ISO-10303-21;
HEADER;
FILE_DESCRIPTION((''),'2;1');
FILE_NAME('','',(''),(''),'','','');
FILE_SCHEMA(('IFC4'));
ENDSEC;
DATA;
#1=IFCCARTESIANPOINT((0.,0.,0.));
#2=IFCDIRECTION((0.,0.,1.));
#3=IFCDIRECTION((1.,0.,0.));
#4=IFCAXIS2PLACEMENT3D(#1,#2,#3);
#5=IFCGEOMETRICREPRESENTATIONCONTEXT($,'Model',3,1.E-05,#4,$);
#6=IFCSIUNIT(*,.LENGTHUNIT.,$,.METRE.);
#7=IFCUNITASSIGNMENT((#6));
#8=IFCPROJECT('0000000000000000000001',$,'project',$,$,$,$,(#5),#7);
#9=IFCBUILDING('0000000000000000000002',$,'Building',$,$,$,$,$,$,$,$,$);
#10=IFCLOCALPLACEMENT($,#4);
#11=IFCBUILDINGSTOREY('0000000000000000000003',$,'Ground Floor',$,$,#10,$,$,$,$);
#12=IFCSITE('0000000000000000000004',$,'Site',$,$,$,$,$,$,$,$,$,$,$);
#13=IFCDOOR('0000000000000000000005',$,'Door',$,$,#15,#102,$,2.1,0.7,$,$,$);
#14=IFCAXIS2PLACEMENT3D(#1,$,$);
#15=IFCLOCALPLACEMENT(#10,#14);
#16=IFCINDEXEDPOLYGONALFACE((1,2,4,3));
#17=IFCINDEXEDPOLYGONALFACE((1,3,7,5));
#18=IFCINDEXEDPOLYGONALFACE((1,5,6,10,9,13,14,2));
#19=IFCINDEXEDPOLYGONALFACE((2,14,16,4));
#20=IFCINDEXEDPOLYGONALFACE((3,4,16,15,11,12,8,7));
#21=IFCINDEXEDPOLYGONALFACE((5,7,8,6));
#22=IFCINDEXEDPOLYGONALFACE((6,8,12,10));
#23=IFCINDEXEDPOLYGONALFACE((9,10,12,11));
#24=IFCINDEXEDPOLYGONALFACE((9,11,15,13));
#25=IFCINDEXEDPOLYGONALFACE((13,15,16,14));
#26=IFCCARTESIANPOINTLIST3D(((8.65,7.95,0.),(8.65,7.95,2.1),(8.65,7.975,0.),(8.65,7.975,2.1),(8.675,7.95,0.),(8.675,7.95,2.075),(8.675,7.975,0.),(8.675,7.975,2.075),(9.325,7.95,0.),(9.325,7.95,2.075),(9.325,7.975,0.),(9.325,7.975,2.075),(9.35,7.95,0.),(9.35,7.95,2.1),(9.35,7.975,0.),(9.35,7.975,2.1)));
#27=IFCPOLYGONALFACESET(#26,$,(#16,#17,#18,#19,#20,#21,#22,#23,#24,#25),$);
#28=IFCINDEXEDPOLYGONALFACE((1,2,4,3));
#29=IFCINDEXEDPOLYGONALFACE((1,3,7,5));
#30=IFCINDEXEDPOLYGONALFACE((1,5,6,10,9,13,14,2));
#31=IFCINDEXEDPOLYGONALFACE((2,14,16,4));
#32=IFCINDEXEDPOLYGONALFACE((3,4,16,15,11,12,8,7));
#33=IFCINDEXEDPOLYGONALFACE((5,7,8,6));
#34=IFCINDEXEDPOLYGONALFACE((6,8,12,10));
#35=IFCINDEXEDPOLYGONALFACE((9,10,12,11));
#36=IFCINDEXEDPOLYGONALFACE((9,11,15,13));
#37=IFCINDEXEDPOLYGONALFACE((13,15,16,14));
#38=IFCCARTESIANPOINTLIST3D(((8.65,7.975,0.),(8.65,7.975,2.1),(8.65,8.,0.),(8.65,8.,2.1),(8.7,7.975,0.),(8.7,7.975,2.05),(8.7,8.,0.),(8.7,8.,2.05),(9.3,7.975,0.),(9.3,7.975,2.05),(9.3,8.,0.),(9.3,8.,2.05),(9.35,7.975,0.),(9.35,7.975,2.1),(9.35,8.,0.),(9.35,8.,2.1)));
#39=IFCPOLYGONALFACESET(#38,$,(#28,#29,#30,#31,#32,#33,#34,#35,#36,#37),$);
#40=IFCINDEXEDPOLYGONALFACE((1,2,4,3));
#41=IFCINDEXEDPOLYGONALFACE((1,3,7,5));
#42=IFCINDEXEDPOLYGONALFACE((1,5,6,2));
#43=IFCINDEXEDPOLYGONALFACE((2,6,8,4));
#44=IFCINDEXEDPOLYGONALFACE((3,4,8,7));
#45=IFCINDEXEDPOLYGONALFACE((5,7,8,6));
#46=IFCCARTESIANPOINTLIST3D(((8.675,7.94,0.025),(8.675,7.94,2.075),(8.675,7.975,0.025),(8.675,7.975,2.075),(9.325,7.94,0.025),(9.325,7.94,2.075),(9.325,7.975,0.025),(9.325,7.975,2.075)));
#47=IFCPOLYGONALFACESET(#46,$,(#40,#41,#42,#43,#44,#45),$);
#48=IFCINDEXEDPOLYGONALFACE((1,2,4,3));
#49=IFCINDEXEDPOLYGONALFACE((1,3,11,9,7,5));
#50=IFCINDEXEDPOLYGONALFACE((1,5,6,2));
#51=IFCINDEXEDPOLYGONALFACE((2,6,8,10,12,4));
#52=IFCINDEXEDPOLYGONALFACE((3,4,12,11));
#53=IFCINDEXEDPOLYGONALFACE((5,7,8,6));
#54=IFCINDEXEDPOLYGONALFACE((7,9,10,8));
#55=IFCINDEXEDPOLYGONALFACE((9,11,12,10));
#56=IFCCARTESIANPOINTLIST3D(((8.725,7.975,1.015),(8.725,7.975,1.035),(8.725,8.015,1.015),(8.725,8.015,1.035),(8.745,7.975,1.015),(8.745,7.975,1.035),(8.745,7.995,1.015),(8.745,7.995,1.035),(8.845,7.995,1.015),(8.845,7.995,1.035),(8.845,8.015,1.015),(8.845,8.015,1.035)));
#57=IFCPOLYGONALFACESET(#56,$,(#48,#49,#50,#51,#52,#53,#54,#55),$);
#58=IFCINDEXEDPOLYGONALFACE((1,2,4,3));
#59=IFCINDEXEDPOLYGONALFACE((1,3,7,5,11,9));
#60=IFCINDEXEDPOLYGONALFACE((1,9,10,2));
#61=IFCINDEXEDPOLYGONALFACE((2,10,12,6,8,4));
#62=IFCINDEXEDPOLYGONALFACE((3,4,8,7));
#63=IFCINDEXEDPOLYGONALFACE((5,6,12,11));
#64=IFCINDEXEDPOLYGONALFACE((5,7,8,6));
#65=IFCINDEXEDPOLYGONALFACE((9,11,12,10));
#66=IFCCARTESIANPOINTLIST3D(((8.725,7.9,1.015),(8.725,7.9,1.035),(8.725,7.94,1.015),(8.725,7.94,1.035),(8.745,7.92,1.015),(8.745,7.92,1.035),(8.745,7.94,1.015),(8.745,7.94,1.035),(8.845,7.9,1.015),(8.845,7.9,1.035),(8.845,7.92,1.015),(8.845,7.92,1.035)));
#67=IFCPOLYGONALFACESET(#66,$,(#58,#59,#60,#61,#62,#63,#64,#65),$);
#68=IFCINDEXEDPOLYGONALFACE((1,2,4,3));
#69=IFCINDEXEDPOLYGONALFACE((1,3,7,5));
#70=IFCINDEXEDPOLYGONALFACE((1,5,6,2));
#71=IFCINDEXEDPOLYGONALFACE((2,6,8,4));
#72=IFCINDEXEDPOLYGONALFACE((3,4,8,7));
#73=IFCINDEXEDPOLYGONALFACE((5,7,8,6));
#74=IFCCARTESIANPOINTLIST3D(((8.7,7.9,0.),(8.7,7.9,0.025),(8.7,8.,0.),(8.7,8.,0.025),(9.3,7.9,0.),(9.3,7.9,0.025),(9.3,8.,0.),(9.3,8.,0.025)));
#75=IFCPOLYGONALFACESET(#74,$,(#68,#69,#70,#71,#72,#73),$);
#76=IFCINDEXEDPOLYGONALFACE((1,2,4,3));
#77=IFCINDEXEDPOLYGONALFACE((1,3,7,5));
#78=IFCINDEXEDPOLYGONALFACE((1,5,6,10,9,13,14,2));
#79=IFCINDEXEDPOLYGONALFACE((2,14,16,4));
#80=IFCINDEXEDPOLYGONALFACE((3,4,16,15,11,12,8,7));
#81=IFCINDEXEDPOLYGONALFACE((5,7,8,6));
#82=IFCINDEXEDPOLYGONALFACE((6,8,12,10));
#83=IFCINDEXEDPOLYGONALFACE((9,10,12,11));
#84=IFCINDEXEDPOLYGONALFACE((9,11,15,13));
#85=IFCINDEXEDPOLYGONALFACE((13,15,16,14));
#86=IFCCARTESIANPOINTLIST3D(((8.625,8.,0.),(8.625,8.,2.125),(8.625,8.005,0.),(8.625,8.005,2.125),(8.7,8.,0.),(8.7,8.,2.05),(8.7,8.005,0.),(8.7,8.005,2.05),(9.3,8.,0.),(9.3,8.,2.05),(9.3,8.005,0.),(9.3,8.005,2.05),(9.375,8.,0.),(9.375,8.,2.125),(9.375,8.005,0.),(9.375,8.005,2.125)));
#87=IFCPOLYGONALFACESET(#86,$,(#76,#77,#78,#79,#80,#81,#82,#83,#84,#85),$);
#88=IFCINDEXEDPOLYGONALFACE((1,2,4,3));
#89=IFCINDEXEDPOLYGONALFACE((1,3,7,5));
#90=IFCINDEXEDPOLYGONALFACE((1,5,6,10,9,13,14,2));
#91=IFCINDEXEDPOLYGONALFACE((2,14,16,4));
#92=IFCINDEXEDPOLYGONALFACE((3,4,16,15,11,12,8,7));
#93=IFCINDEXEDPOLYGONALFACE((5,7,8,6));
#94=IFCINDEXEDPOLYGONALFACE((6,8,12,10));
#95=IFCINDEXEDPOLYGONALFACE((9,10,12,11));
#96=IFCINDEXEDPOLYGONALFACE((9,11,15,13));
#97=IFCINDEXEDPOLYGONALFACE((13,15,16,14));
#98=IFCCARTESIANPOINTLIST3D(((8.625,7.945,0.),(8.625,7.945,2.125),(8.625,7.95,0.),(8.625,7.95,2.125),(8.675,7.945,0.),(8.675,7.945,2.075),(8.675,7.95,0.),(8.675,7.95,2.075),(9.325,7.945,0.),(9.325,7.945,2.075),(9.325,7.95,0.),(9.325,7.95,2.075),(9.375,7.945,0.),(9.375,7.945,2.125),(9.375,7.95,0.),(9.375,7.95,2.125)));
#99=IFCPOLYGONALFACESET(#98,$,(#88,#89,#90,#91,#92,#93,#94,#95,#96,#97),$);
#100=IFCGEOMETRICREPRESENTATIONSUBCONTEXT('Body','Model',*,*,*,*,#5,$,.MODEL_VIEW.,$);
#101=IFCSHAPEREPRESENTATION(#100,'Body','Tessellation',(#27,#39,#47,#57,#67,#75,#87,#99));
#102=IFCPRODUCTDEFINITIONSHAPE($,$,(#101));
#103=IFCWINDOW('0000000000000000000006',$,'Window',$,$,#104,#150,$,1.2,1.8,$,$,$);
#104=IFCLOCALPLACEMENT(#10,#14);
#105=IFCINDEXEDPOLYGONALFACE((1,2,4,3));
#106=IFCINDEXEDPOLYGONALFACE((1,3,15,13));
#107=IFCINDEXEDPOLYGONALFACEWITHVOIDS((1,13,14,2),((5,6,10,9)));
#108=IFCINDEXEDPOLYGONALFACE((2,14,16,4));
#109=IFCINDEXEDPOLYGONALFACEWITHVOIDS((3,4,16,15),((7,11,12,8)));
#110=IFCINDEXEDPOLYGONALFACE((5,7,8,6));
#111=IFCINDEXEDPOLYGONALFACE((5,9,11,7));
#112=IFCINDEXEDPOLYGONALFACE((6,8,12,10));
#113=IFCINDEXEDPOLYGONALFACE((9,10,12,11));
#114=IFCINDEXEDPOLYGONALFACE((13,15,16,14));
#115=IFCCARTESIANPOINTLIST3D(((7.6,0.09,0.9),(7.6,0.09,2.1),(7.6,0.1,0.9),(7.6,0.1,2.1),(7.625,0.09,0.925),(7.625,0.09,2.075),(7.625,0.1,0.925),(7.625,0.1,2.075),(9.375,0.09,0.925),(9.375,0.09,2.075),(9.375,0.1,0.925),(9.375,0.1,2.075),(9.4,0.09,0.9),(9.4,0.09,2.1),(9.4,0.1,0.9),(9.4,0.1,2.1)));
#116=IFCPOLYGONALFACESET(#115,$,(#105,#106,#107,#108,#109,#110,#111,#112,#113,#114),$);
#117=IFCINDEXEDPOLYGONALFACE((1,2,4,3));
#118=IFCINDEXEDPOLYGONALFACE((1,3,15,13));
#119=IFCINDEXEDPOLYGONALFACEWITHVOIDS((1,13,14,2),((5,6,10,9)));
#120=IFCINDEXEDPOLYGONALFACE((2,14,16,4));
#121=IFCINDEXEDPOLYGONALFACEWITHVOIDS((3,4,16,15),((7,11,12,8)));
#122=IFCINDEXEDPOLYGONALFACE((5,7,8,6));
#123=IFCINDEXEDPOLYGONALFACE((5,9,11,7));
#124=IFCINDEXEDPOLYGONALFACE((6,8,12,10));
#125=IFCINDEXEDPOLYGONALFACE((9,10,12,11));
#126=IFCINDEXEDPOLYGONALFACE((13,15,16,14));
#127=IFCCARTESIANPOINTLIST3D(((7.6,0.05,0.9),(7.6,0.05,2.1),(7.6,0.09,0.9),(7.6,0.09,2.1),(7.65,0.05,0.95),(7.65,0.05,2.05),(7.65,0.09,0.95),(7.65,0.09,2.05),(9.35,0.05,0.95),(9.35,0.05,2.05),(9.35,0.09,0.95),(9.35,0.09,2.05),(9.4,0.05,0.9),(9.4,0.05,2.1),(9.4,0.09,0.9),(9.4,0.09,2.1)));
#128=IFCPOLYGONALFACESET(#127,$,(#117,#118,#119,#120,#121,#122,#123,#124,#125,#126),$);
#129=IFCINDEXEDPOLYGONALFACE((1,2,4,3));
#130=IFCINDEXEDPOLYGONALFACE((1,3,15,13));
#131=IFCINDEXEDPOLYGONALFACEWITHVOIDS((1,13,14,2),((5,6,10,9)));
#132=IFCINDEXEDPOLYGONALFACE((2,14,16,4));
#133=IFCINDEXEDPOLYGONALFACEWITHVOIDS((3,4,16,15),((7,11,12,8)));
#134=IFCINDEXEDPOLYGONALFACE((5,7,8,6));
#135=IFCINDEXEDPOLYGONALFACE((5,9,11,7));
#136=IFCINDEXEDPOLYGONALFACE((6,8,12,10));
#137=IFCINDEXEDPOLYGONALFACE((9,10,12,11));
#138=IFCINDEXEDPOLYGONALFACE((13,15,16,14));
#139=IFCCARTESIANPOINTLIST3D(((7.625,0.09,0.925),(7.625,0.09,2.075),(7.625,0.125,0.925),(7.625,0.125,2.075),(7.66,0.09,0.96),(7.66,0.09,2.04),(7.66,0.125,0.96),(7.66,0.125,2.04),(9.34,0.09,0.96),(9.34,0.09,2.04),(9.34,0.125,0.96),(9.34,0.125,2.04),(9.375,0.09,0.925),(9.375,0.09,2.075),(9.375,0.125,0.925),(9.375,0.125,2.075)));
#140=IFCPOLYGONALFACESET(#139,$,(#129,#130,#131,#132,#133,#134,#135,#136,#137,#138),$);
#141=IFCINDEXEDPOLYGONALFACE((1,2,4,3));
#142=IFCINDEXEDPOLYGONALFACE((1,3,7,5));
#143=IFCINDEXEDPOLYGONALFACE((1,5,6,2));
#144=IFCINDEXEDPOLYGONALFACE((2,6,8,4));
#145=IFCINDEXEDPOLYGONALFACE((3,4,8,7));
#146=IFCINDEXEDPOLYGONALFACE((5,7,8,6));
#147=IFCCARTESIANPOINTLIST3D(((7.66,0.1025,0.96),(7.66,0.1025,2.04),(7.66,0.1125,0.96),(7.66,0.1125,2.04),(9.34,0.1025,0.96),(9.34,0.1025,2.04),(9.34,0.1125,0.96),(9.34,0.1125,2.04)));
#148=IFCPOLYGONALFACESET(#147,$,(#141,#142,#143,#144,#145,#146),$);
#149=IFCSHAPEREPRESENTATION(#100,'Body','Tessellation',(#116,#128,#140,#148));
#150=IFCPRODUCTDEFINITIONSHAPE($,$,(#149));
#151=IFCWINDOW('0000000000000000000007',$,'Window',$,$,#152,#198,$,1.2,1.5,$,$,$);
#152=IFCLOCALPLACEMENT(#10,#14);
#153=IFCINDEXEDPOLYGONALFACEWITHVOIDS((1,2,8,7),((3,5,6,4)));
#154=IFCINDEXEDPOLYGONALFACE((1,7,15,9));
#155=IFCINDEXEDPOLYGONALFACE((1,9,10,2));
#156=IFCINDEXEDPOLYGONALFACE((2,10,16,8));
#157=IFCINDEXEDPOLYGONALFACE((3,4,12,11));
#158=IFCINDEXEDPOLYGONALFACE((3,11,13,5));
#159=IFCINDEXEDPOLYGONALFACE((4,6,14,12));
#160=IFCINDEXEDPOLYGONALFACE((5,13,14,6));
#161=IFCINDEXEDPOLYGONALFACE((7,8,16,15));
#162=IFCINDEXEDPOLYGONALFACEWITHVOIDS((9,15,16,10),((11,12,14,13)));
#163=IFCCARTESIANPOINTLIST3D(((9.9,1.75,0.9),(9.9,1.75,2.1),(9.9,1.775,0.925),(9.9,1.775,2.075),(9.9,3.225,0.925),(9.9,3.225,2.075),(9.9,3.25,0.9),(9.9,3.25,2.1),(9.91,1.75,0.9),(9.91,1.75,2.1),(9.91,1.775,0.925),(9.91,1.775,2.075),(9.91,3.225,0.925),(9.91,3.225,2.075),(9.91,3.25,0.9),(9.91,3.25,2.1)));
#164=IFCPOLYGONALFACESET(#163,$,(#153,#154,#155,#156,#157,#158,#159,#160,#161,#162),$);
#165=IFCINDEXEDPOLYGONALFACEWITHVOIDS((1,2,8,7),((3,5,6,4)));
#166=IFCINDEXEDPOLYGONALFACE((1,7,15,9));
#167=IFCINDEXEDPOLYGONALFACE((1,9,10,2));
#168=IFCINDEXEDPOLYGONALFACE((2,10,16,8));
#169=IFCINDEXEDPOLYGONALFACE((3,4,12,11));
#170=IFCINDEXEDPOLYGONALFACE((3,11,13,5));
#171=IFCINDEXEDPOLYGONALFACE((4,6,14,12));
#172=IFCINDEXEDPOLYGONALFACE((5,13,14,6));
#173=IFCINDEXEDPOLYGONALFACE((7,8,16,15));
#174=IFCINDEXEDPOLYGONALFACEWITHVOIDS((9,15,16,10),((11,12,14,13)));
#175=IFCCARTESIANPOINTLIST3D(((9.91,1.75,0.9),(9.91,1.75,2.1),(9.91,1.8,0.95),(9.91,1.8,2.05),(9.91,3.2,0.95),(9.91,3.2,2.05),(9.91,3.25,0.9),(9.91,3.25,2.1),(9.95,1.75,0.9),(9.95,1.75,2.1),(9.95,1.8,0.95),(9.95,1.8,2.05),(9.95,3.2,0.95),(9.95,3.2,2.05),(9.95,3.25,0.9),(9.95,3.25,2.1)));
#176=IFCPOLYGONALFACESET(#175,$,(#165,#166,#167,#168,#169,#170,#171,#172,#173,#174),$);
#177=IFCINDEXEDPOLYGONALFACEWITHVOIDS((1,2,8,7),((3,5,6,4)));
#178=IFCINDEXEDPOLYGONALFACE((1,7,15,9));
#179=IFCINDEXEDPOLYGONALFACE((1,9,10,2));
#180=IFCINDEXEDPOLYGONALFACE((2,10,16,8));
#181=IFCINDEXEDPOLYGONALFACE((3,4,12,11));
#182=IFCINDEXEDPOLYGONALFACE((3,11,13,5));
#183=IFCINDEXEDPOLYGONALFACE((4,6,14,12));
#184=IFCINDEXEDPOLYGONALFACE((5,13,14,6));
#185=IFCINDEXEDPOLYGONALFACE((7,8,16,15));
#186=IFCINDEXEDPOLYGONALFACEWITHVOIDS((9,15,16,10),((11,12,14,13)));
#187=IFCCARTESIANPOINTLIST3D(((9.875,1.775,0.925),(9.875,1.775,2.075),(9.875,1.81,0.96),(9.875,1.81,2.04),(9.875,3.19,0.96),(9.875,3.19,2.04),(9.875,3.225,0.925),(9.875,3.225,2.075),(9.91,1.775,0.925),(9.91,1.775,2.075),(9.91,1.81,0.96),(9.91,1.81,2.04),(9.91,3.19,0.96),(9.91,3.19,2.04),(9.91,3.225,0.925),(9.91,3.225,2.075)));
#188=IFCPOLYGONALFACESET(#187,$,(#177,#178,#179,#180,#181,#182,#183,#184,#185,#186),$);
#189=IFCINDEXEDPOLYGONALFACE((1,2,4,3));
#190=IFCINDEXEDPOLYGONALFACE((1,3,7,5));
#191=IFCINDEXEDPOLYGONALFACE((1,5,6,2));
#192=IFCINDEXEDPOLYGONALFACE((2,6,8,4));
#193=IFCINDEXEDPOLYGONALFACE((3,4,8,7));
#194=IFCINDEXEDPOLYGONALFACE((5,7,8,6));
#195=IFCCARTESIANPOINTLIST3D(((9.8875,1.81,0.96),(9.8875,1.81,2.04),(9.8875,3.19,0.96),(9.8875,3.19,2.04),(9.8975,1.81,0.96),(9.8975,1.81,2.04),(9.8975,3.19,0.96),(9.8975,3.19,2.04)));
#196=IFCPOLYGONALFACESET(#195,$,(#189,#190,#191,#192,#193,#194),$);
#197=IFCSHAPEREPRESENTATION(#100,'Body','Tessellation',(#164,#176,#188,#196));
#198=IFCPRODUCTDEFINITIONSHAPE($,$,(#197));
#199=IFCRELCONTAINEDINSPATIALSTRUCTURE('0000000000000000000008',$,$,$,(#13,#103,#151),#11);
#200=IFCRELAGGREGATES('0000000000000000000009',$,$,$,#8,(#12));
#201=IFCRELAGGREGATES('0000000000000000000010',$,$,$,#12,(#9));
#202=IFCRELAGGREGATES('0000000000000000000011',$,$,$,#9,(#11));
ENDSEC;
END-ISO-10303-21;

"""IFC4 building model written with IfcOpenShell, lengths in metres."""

from ifc_helpers import new_model, si_unit, frame, origin_with_axes, place, context, subcontext, project, spatial, line, indexed_curve, outline, extrude, element, save


model = new_model("IFC4")

# Units and contexts
model_context = context("Model", 3, precision=1e-05, world=origin_with_axes())
body_context = subcontext(model_context, "Body", "Model", "MODEL_VIEW")
ifc_project = project(units=[si_unit("LENGTHUNIT", "METRE")], contexts=[model_context])

# Site, building, storey
site = spatial("IfcSite", under=ifc_project, Name="Site")
building = spatial("IfcBuilding", under=site, Name="Building")
storey_placement = place(None, origin_with_axes())
storey = spatial("IfcBuildingStorey", under=building, at=storey_placement, Name="Ground Floor")

# Door
door_1_placement = place(storey_placement, frame((9.35, 8.0, 0.0), z_axis=(0.0, 0.0, 1.0), x_axis=(-1.0, 0.0, 0.0)))
element("IfcDoor", 1, at=door_1_placement, inside=storey, Name="Door", OverallHeight=2.1, OverallWidth=0.7, context=body_context, shape_type="SweptSolid", body=[
    extrude(outline(indexed_curve([(0.0, 0.0), (0.0, 2.1), (0.7, 2.1), (0.7, 0.0), (0.675, 0.0), (0.675, 2.075), (0.025, 2.075), (0.025, 0.0)], segments=[line(1, 2, 3, 4, 5, 6, 7, 8, 1)])), frame((0.0, 0.025, 0.0), z_axis=(0.0, -1.0, 0.0), x_axis=(1.0, 0.0, 0.0)), (0.0, 0.0, -1.0), 0.025),
    extrude(outline(indexed_curve([(0.0, 0.0), (0.0, 2.1), (0.7, 2.1), (0.7, 0.0), (0.65, 0.0), (0.65, 2.05), (0.05, 2.05), (0.05, 0.0)], segments=[line(1, 2, 3, 4, 5, 6, 7, 8, 1)])), frame((0.0, 0.0, 0.0), z_axis=(0.0, -1.0, 0.0), x_axis=(1.0, 0.0, 0.0)), (0.0, 0.0, -1.0), 0.025),
    extrude(outline(indexed_curve([(0.0, 0.0), (0.65, 0.0), (0.65, 0.035), (0.0, 0.035)], segments=[line(1, 2, 3, 4, 1)])), frame((0.025, 0.025, 0.025), z_axis=(0.0, 0.0, 1.0), x_axis=(1.0, 0.0, 0.0)), (0.0, 0.0, 1.0), 2.05),
    extrude(outline(indexed_curve([(0.0, 0.0), (0.0, -0.04), (-0.12, -0.04), (-0.12, -0.02), (-0.02, -0.02), (-0.02, 0.0)], segments=[line(1, 2, 3, 4, 5, 6, 1)])), frame((0.625, 0.025, 1.015), z_axis=(0.0, 0.0, 1.0), x_axis=(1.0, 0.0, 0.0)), (0.0, 0.0, 1.0), 0.02),
    extrude(outline(indexed_curve([(0.0, 0.0), (0.0, 0.04), (-0.12, 0.04), (-0.12, 0.02), (-0.02, 0.02), (-0.02, 0.0)], segments=[line(1, 2, 3, 4, 5, 6, 1)])), frame((0.625, 0.06, 1.015), z_axis=(0.0, 0.0, 1.0), x_axis=(1.0, 0.0, 0.0)), (0.0, 0.0, 1.0), 0.02),
    extrude(outline(indexed_curve([(0.0, 0.0), (0.6, 0.0), (0.6, 0.1), (0.0, 0.1)], segments=[line(1, 2, 3, 4, 1)])), frame((0.05, 0.0, 0.0), z_axis=(0.0, 0.0, 1.0), x_axis=(1.0, 0.0, 0.0)), (0.0, 0.0, 1.0), 0.025),
    extrude(outline(indexed_curve([(0.0, 0.0), (0.0, 2.125), (0.75, 2.125), (0.75, 0.0), (0.675, 0.0), (0.675, 2.05), (0.075, 2.05), (0.075, 0.0)], segments=[line(1, 2, 3, 4, 5, 6, 7, 8, 1)])), frame((-0.025, -0.005, 0.0), z_axis=(0.0, -1.0, 0.0), x_axis=(1.0, 0.0, 0.0)), (0.0, 0.0, -1.0), 0.005),
    extrude(outline(indexed_curve([(0.0, 0.0), (0.0, 2.125), (0.75, 2.125), (0.75, 0.0), (0.7, 0.0), (0.7, 2.075), (0.05, 2.075), (0.05, 0.0)], segments=[line(1, 2, 3, 4, 5, 6, 7, 8, 1)])), frame((-0.025, 0.05, 0.0), z_axis=(0.0, -1.0, 0.0), x_axis=(1.0, 0.0, 0.0)), (0.0, 0.0, -1.0), 0.005),
])

# Windows
window_1_placement = place(storey_placement, frame((7.6, 0.0, 0.9), z_axis=(0.0, 0.0, 1.0), x_axis=(1.0, 0.0, 0.0)))
element("IfcWindow", 2, at=window_1_placement, inside=storey, Name="Window", OverallHeight=1.2, OverallWidth=1.8, context=body_context, shape_type="SweptSolid", body=[
    extrude(outline(indexed_curve([(0.0, 0.0), (1.8, 0.0), (1.8, 1.2), (0.0, 1.2)], segments=[line(1, 2, 3, 4, 1)]), holes=[indexed_curve([(0.025, 0.025), (1.775, 0.025), (1.775, 1.175), (0.025, 1.175)], segments=[line(1, 2, 3, 4, 1)])]), frame((0.0, 0.09, 0.0), z_axis=(0.0, -1.0, 0.0), x_axis=(1.0, 0.0, 0.0)), (0.0, 0.0, -1.0), 0.01),
    extrude(outline(indexed_curve([(0.0, 0.0), (1.8, 0.0), (1.8, 1.2), (0.0, 1.2)], segments=[line(1, 2, 3, 4, 1)]), holes=[indexed_curve([(0.05, 0.05), (1.75, 0.05), (1.75, 1.15), (0.05, 1.15)], segments=[line(1, 2, 3, 4, 1)])]), frame((0.0, 0.05, 0.0), z_axis=(0.0, -1.0, 0.0), x_axis=(1.0, 0.0, 0.0)), (0.0, 0.0, -1.0), 0.04),
    extrude(outline(indexed_curve([(0.0, 0.0), (1.75, 0.0), (1.75, 1.15), (0.0, 1.15)], segments=[line(1, 2, 3, 4, 1)]), holes=[indexed_curve([(0.035, 0.035), (1.715, 0.035), (1.715, 1.115), (0.035, 1.115)], segments=[line(1, 2, 3, 4, 1)])]), frame((0.025, 0.09, 0.025), z_axis=(0.0, -1.0, 0.0), x_axis=(1.0, 0.0, 0.0)), (0.0, 0.0, -1.0), 0.035),
    extrude(outline(indexed_curve([(0.035, 0.035), (1.715, 0.035), (1.715, 1.115), (0.035, 1.115)], segments=[line(1, 2, 3, 4, 1)])), frame((0.025, 0.1025, 0.025), z_axis=(0.0, -1.0, 0.0), x_axis=(1.0, 0.0, 0.0)), (0.0, 0.0, -1.0), 0.01),
])
for number, where, z_axis, x_axis, name in (
    (3, (10.0, 1.75, 0.9), (0.0, 0.0, 1.0), (0.0, 1.0, 0.0), "Window"),
):
    element("IfcWindow", number, at=place(storey_placement, frame(where, z_axis=z_axis, x_axis=x_axis)), inside=storey, Name=name, OverallHeight=1.2, OverallWidth=1.5, context=body_context, shape_type="SweptSolid", body=[
        extrude(outline(indexed_curve([(0.0, 0.0), (1.5, 0.0), (1.5, 1.2), (0.0, 1.2)], segments=[line(1, 2, 3, 4, 1)]), holes=[indexed_curve([(0.025, 0.025), (1.475, 0.025), (1.475, 1.175), (0.025, 1.175)], segments=[line(1, 2, 3, 4, 1)])]), frame((0.0, 0.09, 0.0), z_axis=(0.0, -1.0, 0.0), x_axis=(1.0, 0.0, 0.0)), (0.0, 0.0, -1.0), 0.01),
        extrude(outline(indexed_curve([(0.0, 0.0), (1.5, 0.0), (1.5, 1.2), (0.0, 1.2)], segments=[line(1, 2, 3, 4, 1)]), holes=[indexed_curve([(0.05, 0.05), (1.45, 0.05), (1.45, 1.15), (0.05, 1.15)], segments=[line(1, 2, 3, 4, 1)])]), frame((0.0, 0.05, 0.0), z_axis=(0.0, -1.0, 0.0), x_axis=(1.0, 0.0, 0.0)), (0.0, 0.0, -1.0), 0.04),
        extrude(outline(indexed_curve([(0.0, 0.0), (1.45, 0.0), (1.45, 1.15), (0.0, 1.15)], segments=[line(1, 2, 3, 4, 1)]), holes=[indexed_curve([(0.035, 0.035), (1.415, 0.035), (1.415, 1.115), (0.035, 1.115)], segments=[line(1, 2, 3, 4, 1)])]), frame((0.025, 0.09, 0.025), z_axis=(0.0, -1.0, 0.0), x_axis=(1.0, 0.0, 0.0)), (0.0, 0.0, -1.0), 0.035),
        extrude(outline(indexed_curve([(0.035, 0.035), (1.415, 0.035), (1.415, 1.115), (0.035, 1.115)], segments=[line(1, 2, 3, 4, 1)])), frame((0.025, 0.1025, 0.025), z_axis=(0.0, -1.0, 0.0), x_axis=(1.0, 0.0, 0.0)), (0.0, 0.0, -1.0), 0.01),
    ])

save(model, "model.ifc")
